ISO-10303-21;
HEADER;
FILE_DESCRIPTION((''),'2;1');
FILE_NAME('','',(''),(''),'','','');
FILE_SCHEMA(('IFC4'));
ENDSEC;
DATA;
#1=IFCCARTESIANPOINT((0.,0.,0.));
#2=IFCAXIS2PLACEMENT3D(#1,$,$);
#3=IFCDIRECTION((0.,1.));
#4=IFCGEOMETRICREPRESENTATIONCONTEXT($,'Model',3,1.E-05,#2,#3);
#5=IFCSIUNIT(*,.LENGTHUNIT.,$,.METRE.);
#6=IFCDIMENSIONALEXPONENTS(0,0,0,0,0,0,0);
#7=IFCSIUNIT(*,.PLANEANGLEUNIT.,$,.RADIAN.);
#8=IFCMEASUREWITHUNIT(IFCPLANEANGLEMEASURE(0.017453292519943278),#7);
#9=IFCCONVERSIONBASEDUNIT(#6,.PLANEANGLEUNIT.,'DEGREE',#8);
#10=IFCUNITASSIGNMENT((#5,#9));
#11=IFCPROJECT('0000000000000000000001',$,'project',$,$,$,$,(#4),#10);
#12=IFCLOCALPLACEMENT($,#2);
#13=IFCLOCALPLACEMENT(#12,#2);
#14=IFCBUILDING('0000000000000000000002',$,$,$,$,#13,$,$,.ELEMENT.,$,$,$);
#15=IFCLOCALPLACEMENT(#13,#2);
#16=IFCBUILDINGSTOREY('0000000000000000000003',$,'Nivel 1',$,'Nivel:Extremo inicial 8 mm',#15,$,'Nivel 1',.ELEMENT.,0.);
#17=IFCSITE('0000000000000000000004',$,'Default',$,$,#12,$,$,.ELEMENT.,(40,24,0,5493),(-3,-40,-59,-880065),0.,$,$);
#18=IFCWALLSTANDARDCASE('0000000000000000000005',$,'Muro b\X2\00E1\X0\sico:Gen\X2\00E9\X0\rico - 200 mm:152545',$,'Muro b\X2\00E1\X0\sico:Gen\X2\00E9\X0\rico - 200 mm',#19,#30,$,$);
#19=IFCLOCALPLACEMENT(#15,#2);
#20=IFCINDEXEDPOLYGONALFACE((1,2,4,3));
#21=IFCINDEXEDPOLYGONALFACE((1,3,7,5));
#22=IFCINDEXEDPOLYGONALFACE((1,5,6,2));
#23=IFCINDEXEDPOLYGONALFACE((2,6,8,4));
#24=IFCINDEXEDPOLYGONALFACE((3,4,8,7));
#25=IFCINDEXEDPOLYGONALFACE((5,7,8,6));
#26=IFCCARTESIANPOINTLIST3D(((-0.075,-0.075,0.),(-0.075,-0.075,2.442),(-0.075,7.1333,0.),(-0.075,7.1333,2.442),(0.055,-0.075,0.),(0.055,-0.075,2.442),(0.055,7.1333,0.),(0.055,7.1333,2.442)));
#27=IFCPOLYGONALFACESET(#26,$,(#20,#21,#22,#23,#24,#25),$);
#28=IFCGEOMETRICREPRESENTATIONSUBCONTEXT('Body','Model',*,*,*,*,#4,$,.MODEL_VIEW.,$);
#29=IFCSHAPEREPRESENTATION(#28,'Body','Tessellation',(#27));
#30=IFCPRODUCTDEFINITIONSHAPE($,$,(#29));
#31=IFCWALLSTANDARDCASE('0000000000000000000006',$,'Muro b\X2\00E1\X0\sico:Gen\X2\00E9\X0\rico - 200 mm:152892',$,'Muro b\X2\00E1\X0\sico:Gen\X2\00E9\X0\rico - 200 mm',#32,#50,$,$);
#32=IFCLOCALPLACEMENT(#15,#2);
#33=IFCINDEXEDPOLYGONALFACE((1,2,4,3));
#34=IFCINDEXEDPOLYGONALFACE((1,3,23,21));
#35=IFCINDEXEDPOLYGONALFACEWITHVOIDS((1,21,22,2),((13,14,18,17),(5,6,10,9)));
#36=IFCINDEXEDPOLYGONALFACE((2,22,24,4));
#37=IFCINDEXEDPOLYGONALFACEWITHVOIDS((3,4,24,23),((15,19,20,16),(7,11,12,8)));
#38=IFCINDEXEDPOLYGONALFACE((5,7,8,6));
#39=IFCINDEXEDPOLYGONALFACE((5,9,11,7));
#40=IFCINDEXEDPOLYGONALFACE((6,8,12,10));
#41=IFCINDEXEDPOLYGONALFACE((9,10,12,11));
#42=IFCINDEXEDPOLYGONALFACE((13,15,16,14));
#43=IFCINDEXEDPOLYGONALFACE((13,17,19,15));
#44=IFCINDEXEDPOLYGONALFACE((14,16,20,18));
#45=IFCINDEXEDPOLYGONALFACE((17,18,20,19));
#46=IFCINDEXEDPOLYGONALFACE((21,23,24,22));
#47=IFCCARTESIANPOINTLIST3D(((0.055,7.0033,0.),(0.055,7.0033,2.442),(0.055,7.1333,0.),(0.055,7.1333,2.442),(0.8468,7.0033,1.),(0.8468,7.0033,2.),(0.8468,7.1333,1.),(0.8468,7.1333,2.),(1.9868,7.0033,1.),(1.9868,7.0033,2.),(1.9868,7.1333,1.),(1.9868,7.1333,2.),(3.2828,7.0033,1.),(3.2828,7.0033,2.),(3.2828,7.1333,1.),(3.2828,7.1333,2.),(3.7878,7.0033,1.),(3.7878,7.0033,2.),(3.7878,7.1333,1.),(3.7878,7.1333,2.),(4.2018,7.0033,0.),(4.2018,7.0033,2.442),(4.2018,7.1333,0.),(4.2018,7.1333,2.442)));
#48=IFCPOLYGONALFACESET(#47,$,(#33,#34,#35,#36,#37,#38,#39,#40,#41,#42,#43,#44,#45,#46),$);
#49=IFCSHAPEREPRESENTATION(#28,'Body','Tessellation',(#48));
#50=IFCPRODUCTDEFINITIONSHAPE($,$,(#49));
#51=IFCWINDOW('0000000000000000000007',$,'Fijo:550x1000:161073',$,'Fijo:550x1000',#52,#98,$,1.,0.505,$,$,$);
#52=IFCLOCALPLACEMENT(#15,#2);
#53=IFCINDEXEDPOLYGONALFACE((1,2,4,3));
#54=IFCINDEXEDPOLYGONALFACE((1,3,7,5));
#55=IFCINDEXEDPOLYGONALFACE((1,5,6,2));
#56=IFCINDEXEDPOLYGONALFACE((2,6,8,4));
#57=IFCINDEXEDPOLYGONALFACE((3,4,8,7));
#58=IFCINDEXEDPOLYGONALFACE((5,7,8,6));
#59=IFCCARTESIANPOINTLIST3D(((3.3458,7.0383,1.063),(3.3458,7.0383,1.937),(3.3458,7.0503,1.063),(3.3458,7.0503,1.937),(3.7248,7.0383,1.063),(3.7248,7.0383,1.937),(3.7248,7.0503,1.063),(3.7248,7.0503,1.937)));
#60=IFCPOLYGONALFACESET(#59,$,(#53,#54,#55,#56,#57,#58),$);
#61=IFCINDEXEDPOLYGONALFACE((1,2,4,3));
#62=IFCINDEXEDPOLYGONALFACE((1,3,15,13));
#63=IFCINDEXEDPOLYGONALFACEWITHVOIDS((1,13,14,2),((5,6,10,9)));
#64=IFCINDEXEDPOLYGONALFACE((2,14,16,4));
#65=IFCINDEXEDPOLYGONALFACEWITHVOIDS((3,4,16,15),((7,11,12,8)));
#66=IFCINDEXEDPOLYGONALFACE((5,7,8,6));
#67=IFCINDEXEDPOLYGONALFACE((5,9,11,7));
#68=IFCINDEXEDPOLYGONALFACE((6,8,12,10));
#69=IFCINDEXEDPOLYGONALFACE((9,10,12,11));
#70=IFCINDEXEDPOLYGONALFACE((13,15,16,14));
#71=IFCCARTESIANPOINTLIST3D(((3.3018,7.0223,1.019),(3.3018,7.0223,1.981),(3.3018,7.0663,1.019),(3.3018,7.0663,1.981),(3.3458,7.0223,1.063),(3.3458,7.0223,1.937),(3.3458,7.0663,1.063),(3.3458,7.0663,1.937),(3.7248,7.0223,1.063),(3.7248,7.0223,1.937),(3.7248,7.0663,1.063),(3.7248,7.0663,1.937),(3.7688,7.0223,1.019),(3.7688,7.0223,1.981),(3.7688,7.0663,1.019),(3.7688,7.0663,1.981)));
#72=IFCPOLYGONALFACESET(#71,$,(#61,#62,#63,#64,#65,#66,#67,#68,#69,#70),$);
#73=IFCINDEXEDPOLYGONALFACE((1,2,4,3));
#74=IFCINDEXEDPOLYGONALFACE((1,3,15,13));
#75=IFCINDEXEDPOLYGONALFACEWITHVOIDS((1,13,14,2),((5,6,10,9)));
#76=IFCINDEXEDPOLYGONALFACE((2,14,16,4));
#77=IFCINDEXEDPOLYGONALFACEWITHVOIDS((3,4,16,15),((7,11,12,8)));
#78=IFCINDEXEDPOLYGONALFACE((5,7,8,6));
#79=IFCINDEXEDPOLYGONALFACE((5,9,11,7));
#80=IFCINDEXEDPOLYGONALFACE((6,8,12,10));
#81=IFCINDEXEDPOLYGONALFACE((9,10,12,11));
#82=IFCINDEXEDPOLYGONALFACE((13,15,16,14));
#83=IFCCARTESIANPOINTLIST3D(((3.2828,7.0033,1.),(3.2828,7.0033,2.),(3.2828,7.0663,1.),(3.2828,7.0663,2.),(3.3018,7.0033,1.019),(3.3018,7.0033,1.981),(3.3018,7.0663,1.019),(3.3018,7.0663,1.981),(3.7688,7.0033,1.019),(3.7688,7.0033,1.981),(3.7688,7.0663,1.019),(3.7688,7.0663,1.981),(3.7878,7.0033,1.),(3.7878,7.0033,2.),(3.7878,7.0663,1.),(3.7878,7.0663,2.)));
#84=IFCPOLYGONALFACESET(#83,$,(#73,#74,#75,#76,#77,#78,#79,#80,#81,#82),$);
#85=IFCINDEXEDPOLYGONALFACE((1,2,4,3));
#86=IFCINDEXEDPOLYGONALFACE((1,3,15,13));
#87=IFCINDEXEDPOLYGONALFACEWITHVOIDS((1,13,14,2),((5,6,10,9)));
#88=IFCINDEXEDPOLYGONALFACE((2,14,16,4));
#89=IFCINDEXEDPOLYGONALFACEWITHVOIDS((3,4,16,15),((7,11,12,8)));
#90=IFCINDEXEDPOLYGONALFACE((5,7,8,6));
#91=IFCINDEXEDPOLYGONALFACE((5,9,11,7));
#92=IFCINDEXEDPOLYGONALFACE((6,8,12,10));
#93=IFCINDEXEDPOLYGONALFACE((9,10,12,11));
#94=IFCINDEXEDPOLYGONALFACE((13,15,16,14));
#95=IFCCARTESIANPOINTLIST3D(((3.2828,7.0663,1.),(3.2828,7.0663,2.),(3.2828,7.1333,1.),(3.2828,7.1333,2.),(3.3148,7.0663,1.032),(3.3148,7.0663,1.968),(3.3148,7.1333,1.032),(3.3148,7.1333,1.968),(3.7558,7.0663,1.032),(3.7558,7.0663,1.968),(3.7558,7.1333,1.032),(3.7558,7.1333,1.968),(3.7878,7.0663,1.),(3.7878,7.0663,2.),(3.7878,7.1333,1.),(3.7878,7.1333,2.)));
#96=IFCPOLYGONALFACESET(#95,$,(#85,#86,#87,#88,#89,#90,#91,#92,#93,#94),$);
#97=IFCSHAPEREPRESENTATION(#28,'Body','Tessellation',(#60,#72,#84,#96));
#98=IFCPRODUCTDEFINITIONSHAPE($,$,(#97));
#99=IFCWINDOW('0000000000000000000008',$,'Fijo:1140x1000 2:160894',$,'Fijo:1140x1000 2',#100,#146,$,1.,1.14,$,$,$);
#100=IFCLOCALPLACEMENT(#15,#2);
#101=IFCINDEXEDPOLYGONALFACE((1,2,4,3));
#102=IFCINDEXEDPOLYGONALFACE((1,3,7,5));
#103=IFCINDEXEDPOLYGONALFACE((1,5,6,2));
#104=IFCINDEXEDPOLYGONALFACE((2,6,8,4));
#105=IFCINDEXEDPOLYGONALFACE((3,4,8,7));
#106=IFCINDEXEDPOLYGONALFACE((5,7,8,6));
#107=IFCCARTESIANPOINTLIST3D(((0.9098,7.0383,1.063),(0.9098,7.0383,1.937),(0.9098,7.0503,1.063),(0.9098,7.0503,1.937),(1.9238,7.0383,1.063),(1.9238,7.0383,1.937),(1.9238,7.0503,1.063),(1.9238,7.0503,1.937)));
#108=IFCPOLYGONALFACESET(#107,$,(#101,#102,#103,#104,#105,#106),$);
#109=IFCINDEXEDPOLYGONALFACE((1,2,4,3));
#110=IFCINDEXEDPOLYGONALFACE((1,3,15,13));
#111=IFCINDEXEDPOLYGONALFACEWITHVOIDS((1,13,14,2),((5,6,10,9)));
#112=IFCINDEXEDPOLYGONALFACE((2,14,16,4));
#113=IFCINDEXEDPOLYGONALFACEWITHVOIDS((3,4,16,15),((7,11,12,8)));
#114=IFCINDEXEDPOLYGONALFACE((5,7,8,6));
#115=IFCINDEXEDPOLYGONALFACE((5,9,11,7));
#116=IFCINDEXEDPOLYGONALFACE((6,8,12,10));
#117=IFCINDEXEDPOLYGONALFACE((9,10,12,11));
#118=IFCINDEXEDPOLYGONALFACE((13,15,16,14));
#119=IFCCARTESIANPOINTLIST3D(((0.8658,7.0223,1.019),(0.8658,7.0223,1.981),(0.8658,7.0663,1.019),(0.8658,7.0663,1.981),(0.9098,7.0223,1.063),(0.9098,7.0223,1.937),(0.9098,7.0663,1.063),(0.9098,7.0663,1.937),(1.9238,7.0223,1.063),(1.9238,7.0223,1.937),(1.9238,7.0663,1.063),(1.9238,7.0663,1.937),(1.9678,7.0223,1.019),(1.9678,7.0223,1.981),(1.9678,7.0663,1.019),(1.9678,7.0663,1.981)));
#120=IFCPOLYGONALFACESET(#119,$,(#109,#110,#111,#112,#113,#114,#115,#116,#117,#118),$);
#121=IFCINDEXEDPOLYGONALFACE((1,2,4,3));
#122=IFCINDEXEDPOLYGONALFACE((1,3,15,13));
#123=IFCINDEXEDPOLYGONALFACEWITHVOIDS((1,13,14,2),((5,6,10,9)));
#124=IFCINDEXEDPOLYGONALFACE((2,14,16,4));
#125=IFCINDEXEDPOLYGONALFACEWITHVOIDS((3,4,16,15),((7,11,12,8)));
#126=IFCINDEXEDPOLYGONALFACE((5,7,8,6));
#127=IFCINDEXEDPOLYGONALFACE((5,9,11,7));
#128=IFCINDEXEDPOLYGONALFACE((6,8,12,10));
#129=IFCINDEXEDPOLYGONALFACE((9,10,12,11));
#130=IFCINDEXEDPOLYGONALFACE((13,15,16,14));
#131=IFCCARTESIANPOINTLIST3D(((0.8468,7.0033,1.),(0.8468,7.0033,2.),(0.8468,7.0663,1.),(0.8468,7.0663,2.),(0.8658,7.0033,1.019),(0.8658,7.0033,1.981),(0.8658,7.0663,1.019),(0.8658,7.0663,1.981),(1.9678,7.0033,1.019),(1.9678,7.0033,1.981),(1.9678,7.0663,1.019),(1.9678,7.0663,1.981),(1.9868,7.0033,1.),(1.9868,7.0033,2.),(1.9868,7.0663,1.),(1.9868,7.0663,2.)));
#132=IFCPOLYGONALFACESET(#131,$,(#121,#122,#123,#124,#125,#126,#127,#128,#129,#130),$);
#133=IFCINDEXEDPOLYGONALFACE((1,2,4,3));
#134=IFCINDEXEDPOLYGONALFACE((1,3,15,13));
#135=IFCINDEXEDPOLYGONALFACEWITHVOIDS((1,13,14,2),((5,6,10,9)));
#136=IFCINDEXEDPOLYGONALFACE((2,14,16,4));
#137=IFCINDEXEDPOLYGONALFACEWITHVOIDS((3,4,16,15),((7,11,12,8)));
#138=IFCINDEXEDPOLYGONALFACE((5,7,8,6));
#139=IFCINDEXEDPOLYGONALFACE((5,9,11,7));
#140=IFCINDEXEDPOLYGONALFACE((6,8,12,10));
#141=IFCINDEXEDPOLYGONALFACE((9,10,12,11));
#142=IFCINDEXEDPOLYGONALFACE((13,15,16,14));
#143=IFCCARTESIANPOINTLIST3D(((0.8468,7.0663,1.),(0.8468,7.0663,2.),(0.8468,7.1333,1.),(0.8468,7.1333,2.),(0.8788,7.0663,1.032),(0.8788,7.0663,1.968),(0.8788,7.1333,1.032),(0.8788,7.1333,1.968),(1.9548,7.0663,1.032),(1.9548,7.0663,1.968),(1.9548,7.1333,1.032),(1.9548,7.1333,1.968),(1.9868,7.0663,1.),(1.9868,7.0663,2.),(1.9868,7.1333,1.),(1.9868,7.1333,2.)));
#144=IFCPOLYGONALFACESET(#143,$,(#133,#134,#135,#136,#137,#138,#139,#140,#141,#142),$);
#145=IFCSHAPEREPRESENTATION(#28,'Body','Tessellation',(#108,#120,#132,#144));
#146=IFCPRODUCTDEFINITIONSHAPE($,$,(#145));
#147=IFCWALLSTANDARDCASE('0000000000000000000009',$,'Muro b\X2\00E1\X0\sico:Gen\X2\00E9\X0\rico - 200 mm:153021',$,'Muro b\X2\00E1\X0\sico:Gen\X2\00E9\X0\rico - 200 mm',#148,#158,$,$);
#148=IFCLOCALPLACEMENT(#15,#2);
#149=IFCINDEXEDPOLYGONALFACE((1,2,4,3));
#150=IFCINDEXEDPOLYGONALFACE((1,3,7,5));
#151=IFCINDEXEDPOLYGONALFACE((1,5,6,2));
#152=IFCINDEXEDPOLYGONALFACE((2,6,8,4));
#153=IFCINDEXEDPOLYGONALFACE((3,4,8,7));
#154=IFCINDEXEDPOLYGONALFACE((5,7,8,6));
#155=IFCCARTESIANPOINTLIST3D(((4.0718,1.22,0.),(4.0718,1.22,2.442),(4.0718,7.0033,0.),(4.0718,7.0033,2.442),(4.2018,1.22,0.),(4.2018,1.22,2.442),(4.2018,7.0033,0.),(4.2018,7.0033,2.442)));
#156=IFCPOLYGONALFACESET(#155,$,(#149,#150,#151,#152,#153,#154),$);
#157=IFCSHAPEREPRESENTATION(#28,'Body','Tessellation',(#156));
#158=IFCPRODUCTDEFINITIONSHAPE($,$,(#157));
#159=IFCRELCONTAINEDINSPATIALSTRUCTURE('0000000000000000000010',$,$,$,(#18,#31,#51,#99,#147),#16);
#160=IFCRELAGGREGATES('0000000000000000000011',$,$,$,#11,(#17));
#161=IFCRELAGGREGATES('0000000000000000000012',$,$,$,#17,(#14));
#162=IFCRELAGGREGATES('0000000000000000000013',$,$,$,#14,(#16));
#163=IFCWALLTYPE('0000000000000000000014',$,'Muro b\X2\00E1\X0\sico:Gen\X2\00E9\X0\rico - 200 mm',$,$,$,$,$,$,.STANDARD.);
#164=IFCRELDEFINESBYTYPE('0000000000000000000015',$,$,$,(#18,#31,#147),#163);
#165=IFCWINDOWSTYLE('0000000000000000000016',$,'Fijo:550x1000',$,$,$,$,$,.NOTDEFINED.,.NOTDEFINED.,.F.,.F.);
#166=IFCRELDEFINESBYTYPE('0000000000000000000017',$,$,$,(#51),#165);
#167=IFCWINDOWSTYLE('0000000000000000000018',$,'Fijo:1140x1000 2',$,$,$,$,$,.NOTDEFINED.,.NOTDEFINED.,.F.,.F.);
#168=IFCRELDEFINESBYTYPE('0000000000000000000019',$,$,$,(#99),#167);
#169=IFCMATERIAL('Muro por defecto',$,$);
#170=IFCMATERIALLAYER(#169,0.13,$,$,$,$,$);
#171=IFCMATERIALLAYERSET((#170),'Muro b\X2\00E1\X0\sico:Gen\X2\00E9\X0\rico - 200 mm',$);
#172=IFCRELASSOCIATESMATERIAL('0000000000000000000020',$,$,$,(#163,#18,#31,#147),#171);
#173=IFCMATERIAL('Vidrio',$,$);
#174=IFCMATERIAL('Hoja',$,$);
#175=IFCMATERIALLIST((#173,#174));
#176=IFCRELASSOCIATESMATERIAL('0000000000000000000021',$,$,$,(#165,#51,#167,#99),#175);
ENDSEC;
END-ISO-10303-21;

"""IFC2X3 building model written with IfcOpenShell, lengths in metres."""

from ifc_helpers import new_model, entity, si_unit, converted_unit, direction, frame, frame_2d, origin, origin_2d_with_axis, place, context, subcontext, project, spatial, polyline, rectangle, outline, extrude, source, transform, mapped, material, material_list, layer, layer_set, layer_usage, type_object, type_shapes, element, fill, save


model = new_model("IFC2X3")

# Units and contexts
model_context = context("Model", 3, precision=1e-05, world=origin(), true_north=direction((0.0, 1.0)))
body_context = subcontext(model_context, "Body", "Model", "MODEL_VIEW")
ifc_project = project(units=[si_unit("LENGTHUNIT", "METRE"), converted_unit("PLANEANGLEUNIT", "DEGREE", entity("IfcPlaneAngleMeasure", 0.017453292519943278), si_unit("PLANEANGLEUNIT", "RADIAN"), dimensions=[0, 0, 0, 0, 0, 0, 0])], contexts=[model_context])

# Site, building, storey
site_placement = place(None, origin())
site = spatial("IfcSite", under=ifc_project, at=site_placement, Name="Default", CompositionType="ELEMENT", RefLatitude=(40, 24, 0, 5493), RefLongitude=(-3, -40, -59, -880065), RefElevation=0.0)
building_placement = place(site_placement, origin())
building = spatial("IfcBuilding", under=site, at=building_placement, CompositionType="ELEMENT")
storey_placement = place(building_placement, origin())
storey = spatial("IfcBuildingStorey", under=building, at=storey_placement, Name="Nivel 1", ObjectType="Nivel:Extremo inicial 8 mm", LongName="Nivel 1", CompositionType="ELEMENT", Elevation=0.0)

# Wall
ifc_material_1 = material(Name="Muro por defecto")
ifc_layer_1 = layer(ifc_material_1, 0.13)
ifc_layer_set_1 = layer_set([ifc_layer_1], Name="Muro básico:Genérico - 200 mm")
ifc_layer_usage_1 = layer_usage(ifc_layer_set_1, "AXIS2", "NEGATIVE", 0.065)
wall_type_1 = type_object("IfcWallType", Name="Muro básico:Genérico - 200 mm", PredefinedType="STANDARD", material=ifc_layer_set_1)
wall_1_placement = place(storey_placement, frame((-0.01, -0.075, 0.0), z_axis=(0.0, 0.0, 1.0), x_axis=(0.0, 1.0, 0.0)))
element("IfcWallStandardCase", 1, at=wall_1_placement, inside=storey, type_object=wall_type_1, material=ifc_layer_usage_1, Name="Muro básico:Genérico - 200 mm:152545", ObjectType="Muro básico:Genérico - 200 mm", context=body_context, shape_type="SweptSolid", body=[
    extrude(rectangle(XDim=7.2083, YDim=0.13, at=frame_2d((3.6042, 0.0), x_axis=(-1.0, 0.0))), origin(), (0.0, 0.0, 1.0), 2.442),
])

# Wall, openings, windows
ifc_layer_usage_2 = layer_usage(ifc_layer_set_1, "AXIS2", "NEGATIVE", 0.065)
wall_2_placement = place(storey_placement, frame((0.055, 7.0683, 0.0)))
wall_2 = element("IfcWallStandardCase", 2, at=wall_2_placement, inside=storey, type_object=wall_type_1, material=ifc_layer_usage_2, Name="Muro básico:Genérico - 200 mm:152892", ObjectType="Muro básico:Genérico - 200 mm", context=body_context, shape_type="SweptSolid", body=[
    extrude(rectangle(XDim=4.1468, YDim=0.13, at=frame_2d((2.0734, 0.0), x_axis=(-1.0, 0.0))), origin(), (0.0, 0.0, 1.0), 2.442),
])
opening_1_placement = place(wall_2_placement, frame((1.9318, 0.065, 1.0)))
opening_1 = element("IfcOpeningElement", 3, at=opening_1_placement, cuts=wall_2, ObjectType="Opening", context=body_context, shape_type="SweptSolid", body=[
    extrude(rectangle(XDim=1.0, YDim=1.14, at=frame_2d((0.5, 0.57), x_axis=(1.0, 0.0))), frame((0.0, 0.0, 0.0), z_axis=(0.0, -1.0, 0.0), x_axis=(0.0, 0.0, 1.0)), (0.0, 0.0, 1.0), 0.13),
])
opening_2_placement = place(wall_2_placement, frame((3.7328, 0.065, 1.0)))
opening_2 = element("IfcOpeningElement", 4, at=opening_2_placement, cuts=wall_2, ObjectType="Opening", context=body_context, shape_type="SweptSolid", body=[
    extrude(rectangle(XDim=1.0, YDim=0.505, at=frame_2d((0.5, 0.2525), x_axis=(1.0, 0.0))), frame((0.0, 0.0, 0.0), z_axis=(0.0, -1.0, 0.0), x_axis=(0.0, 0.0, 1.0)), (0.0, 0.0, 1.0), 0.13),
])
ifc_material_2 = material(Name="Vidrio")
ifc_material_3 = material(Name="Hoja")
ifc_material_list_1 = material_list([ifc_material_2, ifc_material_3])
window_style_1 = type_object("IfcWindowStyle", Name="Fijo:550x1000", ConstructionType="NOTDEFINED", OperationType="NOTDEFINED", ParameterTakesPrecedence=False, Sizeable=False, material=ifc_material_list_1)
shared_shape_1 = source(origin(), body_context, "Body", "SweptSolid", [
    extrude(rectangle(XDim=0.012, YDim=0.379, at=origin_2d_with_axis()), frame((0.2525, 0.089, 0.063), z_axis=(0.0, 0.0, 1.0), x_axis=(0.0, -1.0, 0.0)), (0.0, 0.0, 1.0), 0.874),
    extrude(outline(polyline([(-0.2335, -0.481), (0.2335, -0.481), (0.2335, 0.481), (-0.2335, 0.481), (-0.2335, -0.481)]), holes=[polyline([(-0.1895, -0.437), (-0.1895, 0.437), (0.1895, 0.437), (0.1895, -0.437), (-0.1895, -0.437)])]), frame((0.2525, 0.067, 0.5), z_axis=(0.0, 1.0, 0.0), x_axis=(1.0, 0.0, 0.0)), (0.0, 0.0, 1.0), 0.044),
    extrude(outline(polyline([(-0.2525, -0.5), (0.2525, -0.5), (0.2525, 0.5), (-0.2525, 0.5), (-0.2525, -0.5)]), holes=[polyline([(-0.2335, -0.481), (-0.2335, 0.481), (0.2335, 0.481), (0.2335, -0.481), (-0.2335, -0.481)])]), frame((0.2525, 0.067, 0.5), z_axis=(0.0, 1.0, 0.0), x_axis=(1.0, 0.0, 0.0)), (0.0, 0.0, 1.0), 0.063),
    extrude(outline(polyline([(-0.2525, -0.5), (0.2525, -0.5), (0.2525, 0.5), (-0.2525, 0.5), (-0.2525, -0.5)]), holes=[polyline([(-0.2205, -0.468), (-0.2205, 0.468), (0.2205, 0.468), (0.2205, -0.468), (-0.2205, -0.468)])]), frame((0.2525, 0.0, 0.5), z_axis=(0.0, 1.0, 0.0), x_axis=(1.0, 0.0, 0.0)), (0.0, 0.0, 1.0), 0.067),
])
type_shapes(window_style_1, [shared_shape_1])
window_1_placement = place(opening_2_placement, frame((0.0, 0.0, 0.0), z_axis=(0.0, 0.0, 1.0), x_axis=(-1.0, 0.0, 0.0)))
window_1 = element("IfcWindow", 5, at=window_1_placement, inside=storey, type_object=window_style_1, material=ifc_material_list_1, Name="Fijo:550x1000:161073", ObjectType="Fijo:550x1000", OverallHeight=1.0, OverallWidth=0.505, context=body_context, shape_type="MappedRepresentation", body=[
    mapped(shared_shape_1, transform((0.0, 0.0, 0.0), scale=1.0)),
])
fill(opening_2, window_1)
window_style_2 = type_object("IfcWindowStyle", Name="Fijo:1140x1000 2", ConstructionType="NOTDEFINED", OperationType="NOTDEFINED", ParameterTakesPrecedence=False, Sizeable=False, material=ifc_material_list_1)
shared_shape_2 = source(origin(), body_context, "Body", "SweptSolid", [
    extrude(rectangle(XDim=0.012, YDim=1.014, at=origin_2d_with_axis()), frame((0.57, 0.089, 0.063), z_axis=(0.0, 0.0, 1.0), x_axis=(0.0, -1.0, 0.0)), (0.0, 0.0, 1.0), 0.874),
    extrude(outline(polyline([(-0.551, -0.481), (0.551, -0.481), (0.551, 0.481), (-0.551, 0.481), (-0.551, -0.481)]), holes=[polyline([(-0.507, -0.437), (-0.507, 0.437), (0.507, 0.437), (0.507, -0.437), (-0.507, -0.437)])]), frame((0.57, 0.067, 0.5), z_axis=(0.0, 1.0, 0.0), x_axis=(1.0, 0.0, 0.0)), (0.0, 0.0, 1.0), 0.044),
    extrude(outline(polyline([(-0.57, -0.5), (0.57, -0.5), (0.57, 0.5), (-0.57, 0.5), (-0.57, -0.5)]), holes=[polyline([(-0.551, -0.481), (-0.551, 0.481), (0.551, 0.481), (0.551, -0.481), (-0.551, -0.481)])]), frame((0.57, 0.067, 0.5), z_axis=(0.0, 1.0, 0.0), x_axis=(1.0, 0.0, 0.0)), (0.0, 0.0, 1.0), 0.063),
    extrude(outline(polyline([(-0.57, -0.5), (0.57, -0.5), (0.57, 0.5), (-0.57, 0.5), (-0.57, -0.5)]), holes=[polyline([(-0.538, -0.468), (-0.538, 0.468), (0.538, 0.468), (0.538, -0.468), (-0.538, -0.468)])]), frame((0.57, 0.0, 0.5), z_axis=(0.0, 1.0, 0.0), x_axis=(1.0, 0.0, 0.0)), (0.0, 0.0, 1.0), 0.067),
])
type_shapes(window_style_2, [shared_shape_2])
window_2_placement = place(opening_1_placement, frame((0.0, 0.0, 0.0), z_axis=(0.0, 0.0, 1.0), x_axis=(-1.0, 0.0, 0.0)))
window_2 = element("IfcWindow", 6, at=window_2_placement, inside=storey, type_object=window_style_2, material=ifc_material_list_1, Name="Fijo:1140x1000 2:160894", ObjectType="Fijo:1140x1000 2", OverallHeight=1.0, OverallWidth=1.14, context=body_context, shape_type="MappedRepresentation", body=[
    mapped(shared_shape_2, transform((0.0, 0.0, 0.0), scale=1.0)),
])
fill(opening_1, window_2)

# Wall
ifc_layer_usage_3 = layer_usage(ifc_layer_set_1, "AXIS2", "NEGATIVE", 0.065)
wall_3_placement = place(storey_placement, frame((4.1368, 7.0033, 0.0), z_axis=(0.0, 0.0, 1.0), x_axis=(0.0, -1.0, 0.0)))
element("IfcWallStandardCase", 7, at=wall_3_placement, inside=storey, type_object=wall_type_1, material=ifc_layer_usage_3, Name="Muro básico:Genérico - 200 mm:153021", ObjectType="Muro básico:Genérico - 200 mm", context=body_context, shape_type="SweptSolid", body=[
    extrude(rectangle(XDim=5.7833, YDim=0.13, at=frame_2d((2.8917, 0.0), x_axis=(-1.0, 0.0))), origin(), (0.0, 0.0, 1.0), 2.442),
])

save(model, "model.ifc")
